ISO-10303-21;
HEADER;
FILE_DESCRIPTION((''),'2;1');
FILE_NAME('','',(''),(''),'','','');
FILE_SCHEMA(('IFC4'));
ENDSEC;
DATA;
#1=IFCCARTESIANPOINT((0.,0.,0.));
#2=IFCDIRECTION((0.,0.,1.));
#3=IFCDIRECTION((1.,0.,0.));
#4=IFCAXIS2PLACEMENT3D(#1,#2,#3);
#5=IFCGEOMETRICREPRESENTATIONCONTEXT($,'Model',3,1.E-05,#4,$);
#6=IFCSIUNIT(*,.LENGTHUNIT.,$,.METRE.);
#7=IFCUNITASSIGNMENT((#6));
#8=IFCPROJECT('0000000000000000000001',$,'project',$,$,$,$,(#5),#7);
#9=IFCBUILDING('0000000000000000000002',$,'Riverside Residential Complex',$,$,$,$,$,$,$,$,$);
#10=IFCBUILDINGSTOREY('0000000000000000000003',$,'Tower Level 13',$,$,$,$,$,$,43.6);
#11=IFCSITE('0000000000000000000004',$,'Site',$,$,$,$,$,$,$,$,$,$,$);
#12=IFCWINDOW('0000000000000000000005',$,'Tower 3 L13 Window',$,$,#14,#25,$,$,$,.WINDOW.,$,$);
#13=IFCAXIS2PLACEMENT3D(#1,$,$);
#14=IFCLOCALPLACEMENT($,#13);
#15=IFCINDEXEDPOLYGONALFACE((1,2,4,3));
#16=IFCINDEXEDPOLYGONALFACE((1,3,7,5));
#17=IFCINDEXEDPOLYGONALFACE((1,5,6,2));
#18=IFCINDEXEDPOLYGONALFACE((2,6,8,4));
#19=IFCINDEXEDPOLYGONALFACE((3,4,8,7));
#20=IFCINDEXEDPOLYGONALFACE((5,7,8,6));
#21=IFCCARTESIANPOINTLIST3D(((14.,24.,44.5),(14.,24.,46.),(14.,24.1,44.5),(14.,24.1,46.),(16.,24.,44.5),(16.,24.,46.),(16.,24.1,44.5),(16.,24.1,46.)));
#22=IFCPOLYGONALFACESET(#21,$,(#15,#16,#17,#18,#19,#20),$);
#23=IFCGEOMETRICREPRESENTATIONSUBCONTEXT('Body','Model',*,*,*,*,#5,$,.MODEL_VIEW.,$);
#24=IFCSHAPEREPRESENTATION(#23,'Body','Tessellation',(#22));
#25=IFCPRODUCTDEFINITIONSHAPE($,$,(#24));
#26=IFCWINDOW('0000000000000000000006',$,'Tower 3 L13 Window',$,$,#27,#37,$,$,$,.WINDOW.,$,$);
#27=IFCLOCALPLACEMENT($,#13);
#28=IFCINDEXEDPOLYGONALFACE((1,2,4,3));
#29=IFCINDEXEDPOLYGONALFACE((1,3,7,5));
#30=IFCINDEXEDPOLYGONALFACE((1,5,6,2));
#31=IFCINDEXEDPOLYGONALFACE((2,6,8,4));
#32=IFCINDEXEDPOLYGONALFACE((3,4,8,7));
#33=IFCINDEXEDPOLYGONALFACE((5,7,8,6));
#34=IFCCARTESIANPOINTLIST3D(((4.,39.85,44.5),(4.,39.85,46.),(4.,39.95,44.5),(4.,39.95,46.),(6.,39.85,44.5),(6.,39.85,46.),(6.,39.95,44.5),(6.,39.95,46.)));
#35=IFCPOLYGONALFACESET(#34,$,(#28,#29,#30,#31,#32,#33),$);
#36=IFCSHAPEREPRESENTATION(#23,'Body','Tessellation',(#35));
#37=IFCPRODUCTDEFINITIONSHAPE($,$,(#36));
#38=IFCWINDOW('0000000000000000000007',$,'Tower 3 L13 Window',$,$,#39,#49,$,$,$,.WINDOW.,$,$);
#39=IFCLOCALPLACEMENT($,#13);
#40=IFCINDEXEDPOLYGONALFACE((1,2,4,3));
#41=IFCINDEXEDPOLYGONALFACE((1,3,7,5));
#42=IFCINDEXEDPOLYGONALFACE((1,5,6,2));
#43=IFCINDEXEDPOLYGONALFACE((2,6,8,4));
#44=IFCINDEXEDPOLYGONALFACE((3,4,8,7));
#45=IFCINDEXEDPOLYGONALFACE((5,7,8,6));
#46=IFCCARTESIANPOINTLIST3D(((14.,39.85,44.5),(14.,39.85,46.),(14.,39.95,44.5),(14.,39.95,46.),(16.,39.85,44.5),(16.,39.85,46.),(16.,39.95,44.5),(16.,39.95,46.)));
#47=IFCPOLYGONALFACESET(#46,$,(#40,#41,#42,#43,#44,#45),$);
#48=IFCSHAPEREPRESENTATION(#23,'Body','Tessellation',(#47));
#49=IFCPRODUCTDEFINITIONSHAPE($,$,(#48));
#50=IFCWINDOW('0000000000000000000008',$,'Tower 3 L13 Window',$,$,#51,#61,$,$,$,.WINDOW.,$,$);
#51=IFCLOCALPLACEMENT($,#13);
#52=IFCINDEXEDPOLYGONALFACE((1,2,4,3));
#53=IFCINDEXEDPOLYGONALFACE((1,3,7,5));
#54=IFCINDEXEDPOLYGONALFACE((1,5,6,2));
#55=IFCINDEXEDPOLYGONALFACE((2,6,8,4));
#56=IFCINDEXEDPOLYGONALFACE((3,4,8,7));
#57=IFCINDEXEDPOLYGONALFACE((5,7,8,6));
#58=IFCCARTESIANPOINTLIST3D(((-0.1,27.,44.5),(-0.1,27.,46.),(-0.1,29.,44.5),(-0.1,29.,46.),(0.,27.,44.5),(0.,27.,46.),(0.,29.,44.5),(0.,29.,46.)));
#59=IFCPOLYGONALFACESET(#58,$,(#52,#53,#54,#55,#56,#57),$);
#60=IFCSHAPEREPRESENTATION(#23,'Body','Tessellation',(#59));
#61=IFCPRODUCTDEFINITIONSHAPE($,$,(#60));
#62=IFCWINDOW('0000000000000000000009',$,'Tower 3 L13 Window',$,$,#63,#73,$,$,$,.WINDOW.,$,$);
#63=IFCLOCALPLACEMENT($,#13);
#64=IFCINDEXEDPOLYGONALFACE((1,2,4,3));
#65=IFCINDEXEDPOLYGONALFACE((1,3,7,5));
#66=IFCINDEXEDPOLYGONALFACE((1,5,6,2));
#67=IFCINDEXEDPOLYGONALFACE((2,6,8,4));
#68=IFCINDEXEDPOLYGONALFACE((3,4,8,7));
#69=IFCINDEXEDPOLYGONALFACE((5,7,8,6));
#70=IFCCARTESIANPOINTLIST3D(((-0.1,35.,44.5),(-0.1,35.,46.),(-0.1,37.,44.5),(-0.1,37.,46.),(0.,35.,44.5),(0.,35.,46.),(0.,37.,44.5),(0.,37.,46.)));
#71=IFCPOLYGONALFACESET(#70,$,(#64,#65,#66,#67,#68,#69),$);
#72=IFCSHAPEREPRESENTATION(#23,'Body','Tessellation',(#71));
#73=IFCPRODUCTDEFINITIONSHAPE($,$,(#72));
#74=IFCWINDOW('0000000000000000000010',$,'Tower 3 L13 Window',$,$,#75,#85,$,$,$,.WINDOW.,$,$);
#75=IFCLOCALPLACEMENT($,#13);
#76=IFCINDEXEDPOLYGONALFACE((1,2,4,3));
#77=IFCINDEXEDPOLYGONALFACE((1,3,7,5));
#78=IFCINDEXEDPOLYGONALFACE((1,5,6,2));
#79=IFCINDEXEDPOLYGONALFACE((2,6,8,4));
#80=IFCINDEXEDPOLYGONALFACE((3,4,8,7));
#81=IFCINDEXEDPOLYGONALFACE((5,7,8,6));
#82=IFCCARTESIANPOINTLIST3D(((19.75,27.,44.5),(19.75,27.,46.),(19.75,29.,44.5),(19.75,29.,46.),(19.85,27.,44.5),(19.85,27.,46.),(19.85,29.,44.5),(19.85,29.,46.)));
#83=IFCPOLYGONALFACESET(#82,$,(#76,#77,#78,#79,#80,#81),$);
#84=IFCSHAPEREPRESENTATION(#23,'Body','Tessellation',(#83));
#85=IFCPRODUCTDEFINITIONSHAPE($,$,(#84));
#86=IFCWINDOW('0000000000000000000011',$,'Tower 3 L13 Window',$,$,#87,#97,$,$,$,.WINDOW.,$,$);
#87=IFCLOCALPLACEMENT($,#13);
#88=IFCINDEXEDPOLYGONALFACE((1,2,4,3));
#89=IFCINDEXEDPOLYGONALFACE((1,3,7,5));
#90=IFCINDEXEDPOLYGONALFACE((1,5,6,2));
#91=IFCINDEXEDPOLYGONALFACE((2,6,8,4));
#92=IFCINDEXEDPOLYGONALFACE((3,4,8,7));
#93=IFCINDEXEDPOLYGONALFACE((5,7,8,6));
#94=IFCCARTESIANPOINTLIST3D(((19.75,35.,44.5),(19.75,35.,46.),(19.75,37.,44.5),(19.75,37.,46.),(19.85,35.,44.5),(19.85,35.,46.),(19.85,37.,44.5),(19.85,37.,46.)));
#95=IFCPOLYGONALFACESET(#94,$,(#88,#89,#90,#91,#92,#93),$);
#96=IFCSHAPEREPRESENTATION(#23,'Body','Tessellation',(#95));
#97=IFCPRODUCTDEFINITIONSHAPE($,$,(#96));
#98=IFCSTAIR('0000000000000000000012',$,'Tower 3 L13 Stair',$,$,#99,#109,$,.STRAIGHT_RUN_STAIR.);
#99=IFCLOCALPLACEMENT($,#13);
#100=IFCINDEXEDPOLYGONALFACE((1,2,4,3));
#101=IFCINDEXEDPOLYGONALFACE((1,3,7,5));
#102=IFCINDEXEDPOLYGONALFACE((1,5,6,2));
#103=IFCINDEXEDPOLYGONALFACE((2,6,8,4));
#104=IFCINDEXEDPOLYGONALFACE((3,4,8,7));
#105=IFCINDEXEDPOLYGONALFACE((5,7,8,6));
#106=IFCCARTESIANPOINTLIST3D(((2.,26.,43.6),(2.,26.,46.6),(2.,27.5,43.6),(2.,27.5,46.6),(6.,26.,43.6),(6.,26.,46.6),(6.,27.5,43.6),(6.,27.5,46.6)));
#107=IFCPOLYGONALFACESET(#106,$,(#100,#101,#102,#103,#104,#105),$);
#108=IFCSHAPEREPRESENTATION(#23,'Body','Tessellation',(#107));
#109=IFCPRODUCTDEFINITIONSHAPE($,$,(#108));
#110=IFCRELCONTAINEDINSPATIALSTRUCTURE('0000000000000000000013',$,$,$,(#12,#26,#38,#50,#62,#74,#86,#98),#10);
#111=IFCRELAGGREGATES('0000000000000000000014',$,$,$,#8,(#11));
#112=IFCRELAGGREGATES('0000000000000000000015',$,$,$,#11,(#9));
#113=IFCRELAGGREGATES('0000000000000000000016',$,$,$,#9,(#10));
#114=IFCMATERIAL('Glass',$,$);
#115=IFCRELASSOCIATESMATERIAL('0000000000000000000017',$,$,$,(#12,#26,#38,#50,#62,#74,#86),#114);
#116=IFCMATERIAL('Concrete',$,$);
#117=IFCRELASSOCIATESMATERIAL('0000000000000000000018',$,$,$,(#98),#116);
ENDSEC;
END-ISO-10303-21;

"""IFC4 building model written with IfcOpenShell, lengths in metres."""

from ifc_helpers import new_model, si_unit, frame, origin_with_axes, place, context, subcontext, project, spatial, line, indexed_curve, outline, extrude, material, element, save


model = new_model("IFC4")

# Units and contexts
model_context = context("Model", 3, precision=1e-05, world=origin_with_axes())
body_context = subcontext(model_context, "Body", "Model", "MODEL_VIEW")
ifc_project = project(units=[si_unit("LENGTHUNIT", "METRE")], contexts=[model_context])

# Site, building, storey
site = spatial("IfcSite", under=ifc_project, Name="Site")
building = spatial("IfcBuilding", under=site, Name="Riverside Residential Complex")
storey = spatial("IfcBuildingStorey", under=building, Name="Tower Level 13", Elevation=43.6)

# Shared definitions
ifc_material_1 = material(Name="Concrete")

# Windows
ifc_material_2 = material(Name="Glass")
for number, where, z_axis, x_axis, name in (
    (1, (14.0, 24.0, 44.5), (0.0, 0.0, 1.0), (1.0, 0.0, 0.0), "Tower 3 L13 Window"),
    (2, (4.0, 39.85, 44.5), (0.0, 0.0, 1.0), (1.0, 0.0, 0.0), "Tower 3 L13 Window"),
    (3, (14.0, 39.85, 44.5), (0.0, 0.0, 1.0), (1.0, 0.0, 0.0), "Tower 3 L13 Window"),
    (4, (0.0, 27.0, 44.5), (0.0, 0.0, 1.0), (0.0, 1.0, 0.0), "Tower 3 L13 Window"),
    (5, (0.0, 35.0, 44.5), (0.0, 0.0, 1.0), (0.0, 1.0, 0.0), "Tower 3 L13 Window"),
    (6, (19.85, 27.0, 44.5), (0.0, 0.0, 1.0), (0.0, 1.0, 0.0), "Tower 3 L13 Window"),
    (7, (19.85, 35.0, 44.5), (0.0, 0.0, 1.0), (0.0, 1.0, 0.0), "Tower 3 L13 Window"),
):
    element("IfcWindow", number, at=place(None, frame(where, z_axis=z_axis, x_axis=x_axis)), inside=storey, material=ifc_material_2, Name=name, PredefinedType="WINDOW", context=body_context, shape_type="SweptSolid", body=[
        extrude(outline(indexed_curve([(0.0, 0.0), (2.0, 0.0), (2.0, 0.1), (0.0, 0.1)], segments=[line(1, 2, 3, 4, 1)])), origin_with_axes(), (0.0, 0.0, 1.0), 1.5),
    ])

# Stair
stair_placement = place(None, frame((2.0, 26.0, 43.6), z_axis=(0.0, 0.0, 1.0), x_axis=(1.0, 0.0, 0.0)))
element("IfcStair", 8, at=stair_placement, inside=storey, material=ifc_material_1, Name="Tower 3 L13 Stair", PredefinedType="STRAIGHT_RUN_STAIR", context=body_context, shape_type="SweptSolid", body=[
    extrude(outline(indexed_curve([(0.0, 0.0), (4.0, 0.0), (4.0, 1.5), (0.0, 1.5)], segments=[line(1, 2, 3, 4, 1)])), origin_with_axes(), (0.0, 0.0, 1.0), 3.0),
])

save(model, "model.ifc")
